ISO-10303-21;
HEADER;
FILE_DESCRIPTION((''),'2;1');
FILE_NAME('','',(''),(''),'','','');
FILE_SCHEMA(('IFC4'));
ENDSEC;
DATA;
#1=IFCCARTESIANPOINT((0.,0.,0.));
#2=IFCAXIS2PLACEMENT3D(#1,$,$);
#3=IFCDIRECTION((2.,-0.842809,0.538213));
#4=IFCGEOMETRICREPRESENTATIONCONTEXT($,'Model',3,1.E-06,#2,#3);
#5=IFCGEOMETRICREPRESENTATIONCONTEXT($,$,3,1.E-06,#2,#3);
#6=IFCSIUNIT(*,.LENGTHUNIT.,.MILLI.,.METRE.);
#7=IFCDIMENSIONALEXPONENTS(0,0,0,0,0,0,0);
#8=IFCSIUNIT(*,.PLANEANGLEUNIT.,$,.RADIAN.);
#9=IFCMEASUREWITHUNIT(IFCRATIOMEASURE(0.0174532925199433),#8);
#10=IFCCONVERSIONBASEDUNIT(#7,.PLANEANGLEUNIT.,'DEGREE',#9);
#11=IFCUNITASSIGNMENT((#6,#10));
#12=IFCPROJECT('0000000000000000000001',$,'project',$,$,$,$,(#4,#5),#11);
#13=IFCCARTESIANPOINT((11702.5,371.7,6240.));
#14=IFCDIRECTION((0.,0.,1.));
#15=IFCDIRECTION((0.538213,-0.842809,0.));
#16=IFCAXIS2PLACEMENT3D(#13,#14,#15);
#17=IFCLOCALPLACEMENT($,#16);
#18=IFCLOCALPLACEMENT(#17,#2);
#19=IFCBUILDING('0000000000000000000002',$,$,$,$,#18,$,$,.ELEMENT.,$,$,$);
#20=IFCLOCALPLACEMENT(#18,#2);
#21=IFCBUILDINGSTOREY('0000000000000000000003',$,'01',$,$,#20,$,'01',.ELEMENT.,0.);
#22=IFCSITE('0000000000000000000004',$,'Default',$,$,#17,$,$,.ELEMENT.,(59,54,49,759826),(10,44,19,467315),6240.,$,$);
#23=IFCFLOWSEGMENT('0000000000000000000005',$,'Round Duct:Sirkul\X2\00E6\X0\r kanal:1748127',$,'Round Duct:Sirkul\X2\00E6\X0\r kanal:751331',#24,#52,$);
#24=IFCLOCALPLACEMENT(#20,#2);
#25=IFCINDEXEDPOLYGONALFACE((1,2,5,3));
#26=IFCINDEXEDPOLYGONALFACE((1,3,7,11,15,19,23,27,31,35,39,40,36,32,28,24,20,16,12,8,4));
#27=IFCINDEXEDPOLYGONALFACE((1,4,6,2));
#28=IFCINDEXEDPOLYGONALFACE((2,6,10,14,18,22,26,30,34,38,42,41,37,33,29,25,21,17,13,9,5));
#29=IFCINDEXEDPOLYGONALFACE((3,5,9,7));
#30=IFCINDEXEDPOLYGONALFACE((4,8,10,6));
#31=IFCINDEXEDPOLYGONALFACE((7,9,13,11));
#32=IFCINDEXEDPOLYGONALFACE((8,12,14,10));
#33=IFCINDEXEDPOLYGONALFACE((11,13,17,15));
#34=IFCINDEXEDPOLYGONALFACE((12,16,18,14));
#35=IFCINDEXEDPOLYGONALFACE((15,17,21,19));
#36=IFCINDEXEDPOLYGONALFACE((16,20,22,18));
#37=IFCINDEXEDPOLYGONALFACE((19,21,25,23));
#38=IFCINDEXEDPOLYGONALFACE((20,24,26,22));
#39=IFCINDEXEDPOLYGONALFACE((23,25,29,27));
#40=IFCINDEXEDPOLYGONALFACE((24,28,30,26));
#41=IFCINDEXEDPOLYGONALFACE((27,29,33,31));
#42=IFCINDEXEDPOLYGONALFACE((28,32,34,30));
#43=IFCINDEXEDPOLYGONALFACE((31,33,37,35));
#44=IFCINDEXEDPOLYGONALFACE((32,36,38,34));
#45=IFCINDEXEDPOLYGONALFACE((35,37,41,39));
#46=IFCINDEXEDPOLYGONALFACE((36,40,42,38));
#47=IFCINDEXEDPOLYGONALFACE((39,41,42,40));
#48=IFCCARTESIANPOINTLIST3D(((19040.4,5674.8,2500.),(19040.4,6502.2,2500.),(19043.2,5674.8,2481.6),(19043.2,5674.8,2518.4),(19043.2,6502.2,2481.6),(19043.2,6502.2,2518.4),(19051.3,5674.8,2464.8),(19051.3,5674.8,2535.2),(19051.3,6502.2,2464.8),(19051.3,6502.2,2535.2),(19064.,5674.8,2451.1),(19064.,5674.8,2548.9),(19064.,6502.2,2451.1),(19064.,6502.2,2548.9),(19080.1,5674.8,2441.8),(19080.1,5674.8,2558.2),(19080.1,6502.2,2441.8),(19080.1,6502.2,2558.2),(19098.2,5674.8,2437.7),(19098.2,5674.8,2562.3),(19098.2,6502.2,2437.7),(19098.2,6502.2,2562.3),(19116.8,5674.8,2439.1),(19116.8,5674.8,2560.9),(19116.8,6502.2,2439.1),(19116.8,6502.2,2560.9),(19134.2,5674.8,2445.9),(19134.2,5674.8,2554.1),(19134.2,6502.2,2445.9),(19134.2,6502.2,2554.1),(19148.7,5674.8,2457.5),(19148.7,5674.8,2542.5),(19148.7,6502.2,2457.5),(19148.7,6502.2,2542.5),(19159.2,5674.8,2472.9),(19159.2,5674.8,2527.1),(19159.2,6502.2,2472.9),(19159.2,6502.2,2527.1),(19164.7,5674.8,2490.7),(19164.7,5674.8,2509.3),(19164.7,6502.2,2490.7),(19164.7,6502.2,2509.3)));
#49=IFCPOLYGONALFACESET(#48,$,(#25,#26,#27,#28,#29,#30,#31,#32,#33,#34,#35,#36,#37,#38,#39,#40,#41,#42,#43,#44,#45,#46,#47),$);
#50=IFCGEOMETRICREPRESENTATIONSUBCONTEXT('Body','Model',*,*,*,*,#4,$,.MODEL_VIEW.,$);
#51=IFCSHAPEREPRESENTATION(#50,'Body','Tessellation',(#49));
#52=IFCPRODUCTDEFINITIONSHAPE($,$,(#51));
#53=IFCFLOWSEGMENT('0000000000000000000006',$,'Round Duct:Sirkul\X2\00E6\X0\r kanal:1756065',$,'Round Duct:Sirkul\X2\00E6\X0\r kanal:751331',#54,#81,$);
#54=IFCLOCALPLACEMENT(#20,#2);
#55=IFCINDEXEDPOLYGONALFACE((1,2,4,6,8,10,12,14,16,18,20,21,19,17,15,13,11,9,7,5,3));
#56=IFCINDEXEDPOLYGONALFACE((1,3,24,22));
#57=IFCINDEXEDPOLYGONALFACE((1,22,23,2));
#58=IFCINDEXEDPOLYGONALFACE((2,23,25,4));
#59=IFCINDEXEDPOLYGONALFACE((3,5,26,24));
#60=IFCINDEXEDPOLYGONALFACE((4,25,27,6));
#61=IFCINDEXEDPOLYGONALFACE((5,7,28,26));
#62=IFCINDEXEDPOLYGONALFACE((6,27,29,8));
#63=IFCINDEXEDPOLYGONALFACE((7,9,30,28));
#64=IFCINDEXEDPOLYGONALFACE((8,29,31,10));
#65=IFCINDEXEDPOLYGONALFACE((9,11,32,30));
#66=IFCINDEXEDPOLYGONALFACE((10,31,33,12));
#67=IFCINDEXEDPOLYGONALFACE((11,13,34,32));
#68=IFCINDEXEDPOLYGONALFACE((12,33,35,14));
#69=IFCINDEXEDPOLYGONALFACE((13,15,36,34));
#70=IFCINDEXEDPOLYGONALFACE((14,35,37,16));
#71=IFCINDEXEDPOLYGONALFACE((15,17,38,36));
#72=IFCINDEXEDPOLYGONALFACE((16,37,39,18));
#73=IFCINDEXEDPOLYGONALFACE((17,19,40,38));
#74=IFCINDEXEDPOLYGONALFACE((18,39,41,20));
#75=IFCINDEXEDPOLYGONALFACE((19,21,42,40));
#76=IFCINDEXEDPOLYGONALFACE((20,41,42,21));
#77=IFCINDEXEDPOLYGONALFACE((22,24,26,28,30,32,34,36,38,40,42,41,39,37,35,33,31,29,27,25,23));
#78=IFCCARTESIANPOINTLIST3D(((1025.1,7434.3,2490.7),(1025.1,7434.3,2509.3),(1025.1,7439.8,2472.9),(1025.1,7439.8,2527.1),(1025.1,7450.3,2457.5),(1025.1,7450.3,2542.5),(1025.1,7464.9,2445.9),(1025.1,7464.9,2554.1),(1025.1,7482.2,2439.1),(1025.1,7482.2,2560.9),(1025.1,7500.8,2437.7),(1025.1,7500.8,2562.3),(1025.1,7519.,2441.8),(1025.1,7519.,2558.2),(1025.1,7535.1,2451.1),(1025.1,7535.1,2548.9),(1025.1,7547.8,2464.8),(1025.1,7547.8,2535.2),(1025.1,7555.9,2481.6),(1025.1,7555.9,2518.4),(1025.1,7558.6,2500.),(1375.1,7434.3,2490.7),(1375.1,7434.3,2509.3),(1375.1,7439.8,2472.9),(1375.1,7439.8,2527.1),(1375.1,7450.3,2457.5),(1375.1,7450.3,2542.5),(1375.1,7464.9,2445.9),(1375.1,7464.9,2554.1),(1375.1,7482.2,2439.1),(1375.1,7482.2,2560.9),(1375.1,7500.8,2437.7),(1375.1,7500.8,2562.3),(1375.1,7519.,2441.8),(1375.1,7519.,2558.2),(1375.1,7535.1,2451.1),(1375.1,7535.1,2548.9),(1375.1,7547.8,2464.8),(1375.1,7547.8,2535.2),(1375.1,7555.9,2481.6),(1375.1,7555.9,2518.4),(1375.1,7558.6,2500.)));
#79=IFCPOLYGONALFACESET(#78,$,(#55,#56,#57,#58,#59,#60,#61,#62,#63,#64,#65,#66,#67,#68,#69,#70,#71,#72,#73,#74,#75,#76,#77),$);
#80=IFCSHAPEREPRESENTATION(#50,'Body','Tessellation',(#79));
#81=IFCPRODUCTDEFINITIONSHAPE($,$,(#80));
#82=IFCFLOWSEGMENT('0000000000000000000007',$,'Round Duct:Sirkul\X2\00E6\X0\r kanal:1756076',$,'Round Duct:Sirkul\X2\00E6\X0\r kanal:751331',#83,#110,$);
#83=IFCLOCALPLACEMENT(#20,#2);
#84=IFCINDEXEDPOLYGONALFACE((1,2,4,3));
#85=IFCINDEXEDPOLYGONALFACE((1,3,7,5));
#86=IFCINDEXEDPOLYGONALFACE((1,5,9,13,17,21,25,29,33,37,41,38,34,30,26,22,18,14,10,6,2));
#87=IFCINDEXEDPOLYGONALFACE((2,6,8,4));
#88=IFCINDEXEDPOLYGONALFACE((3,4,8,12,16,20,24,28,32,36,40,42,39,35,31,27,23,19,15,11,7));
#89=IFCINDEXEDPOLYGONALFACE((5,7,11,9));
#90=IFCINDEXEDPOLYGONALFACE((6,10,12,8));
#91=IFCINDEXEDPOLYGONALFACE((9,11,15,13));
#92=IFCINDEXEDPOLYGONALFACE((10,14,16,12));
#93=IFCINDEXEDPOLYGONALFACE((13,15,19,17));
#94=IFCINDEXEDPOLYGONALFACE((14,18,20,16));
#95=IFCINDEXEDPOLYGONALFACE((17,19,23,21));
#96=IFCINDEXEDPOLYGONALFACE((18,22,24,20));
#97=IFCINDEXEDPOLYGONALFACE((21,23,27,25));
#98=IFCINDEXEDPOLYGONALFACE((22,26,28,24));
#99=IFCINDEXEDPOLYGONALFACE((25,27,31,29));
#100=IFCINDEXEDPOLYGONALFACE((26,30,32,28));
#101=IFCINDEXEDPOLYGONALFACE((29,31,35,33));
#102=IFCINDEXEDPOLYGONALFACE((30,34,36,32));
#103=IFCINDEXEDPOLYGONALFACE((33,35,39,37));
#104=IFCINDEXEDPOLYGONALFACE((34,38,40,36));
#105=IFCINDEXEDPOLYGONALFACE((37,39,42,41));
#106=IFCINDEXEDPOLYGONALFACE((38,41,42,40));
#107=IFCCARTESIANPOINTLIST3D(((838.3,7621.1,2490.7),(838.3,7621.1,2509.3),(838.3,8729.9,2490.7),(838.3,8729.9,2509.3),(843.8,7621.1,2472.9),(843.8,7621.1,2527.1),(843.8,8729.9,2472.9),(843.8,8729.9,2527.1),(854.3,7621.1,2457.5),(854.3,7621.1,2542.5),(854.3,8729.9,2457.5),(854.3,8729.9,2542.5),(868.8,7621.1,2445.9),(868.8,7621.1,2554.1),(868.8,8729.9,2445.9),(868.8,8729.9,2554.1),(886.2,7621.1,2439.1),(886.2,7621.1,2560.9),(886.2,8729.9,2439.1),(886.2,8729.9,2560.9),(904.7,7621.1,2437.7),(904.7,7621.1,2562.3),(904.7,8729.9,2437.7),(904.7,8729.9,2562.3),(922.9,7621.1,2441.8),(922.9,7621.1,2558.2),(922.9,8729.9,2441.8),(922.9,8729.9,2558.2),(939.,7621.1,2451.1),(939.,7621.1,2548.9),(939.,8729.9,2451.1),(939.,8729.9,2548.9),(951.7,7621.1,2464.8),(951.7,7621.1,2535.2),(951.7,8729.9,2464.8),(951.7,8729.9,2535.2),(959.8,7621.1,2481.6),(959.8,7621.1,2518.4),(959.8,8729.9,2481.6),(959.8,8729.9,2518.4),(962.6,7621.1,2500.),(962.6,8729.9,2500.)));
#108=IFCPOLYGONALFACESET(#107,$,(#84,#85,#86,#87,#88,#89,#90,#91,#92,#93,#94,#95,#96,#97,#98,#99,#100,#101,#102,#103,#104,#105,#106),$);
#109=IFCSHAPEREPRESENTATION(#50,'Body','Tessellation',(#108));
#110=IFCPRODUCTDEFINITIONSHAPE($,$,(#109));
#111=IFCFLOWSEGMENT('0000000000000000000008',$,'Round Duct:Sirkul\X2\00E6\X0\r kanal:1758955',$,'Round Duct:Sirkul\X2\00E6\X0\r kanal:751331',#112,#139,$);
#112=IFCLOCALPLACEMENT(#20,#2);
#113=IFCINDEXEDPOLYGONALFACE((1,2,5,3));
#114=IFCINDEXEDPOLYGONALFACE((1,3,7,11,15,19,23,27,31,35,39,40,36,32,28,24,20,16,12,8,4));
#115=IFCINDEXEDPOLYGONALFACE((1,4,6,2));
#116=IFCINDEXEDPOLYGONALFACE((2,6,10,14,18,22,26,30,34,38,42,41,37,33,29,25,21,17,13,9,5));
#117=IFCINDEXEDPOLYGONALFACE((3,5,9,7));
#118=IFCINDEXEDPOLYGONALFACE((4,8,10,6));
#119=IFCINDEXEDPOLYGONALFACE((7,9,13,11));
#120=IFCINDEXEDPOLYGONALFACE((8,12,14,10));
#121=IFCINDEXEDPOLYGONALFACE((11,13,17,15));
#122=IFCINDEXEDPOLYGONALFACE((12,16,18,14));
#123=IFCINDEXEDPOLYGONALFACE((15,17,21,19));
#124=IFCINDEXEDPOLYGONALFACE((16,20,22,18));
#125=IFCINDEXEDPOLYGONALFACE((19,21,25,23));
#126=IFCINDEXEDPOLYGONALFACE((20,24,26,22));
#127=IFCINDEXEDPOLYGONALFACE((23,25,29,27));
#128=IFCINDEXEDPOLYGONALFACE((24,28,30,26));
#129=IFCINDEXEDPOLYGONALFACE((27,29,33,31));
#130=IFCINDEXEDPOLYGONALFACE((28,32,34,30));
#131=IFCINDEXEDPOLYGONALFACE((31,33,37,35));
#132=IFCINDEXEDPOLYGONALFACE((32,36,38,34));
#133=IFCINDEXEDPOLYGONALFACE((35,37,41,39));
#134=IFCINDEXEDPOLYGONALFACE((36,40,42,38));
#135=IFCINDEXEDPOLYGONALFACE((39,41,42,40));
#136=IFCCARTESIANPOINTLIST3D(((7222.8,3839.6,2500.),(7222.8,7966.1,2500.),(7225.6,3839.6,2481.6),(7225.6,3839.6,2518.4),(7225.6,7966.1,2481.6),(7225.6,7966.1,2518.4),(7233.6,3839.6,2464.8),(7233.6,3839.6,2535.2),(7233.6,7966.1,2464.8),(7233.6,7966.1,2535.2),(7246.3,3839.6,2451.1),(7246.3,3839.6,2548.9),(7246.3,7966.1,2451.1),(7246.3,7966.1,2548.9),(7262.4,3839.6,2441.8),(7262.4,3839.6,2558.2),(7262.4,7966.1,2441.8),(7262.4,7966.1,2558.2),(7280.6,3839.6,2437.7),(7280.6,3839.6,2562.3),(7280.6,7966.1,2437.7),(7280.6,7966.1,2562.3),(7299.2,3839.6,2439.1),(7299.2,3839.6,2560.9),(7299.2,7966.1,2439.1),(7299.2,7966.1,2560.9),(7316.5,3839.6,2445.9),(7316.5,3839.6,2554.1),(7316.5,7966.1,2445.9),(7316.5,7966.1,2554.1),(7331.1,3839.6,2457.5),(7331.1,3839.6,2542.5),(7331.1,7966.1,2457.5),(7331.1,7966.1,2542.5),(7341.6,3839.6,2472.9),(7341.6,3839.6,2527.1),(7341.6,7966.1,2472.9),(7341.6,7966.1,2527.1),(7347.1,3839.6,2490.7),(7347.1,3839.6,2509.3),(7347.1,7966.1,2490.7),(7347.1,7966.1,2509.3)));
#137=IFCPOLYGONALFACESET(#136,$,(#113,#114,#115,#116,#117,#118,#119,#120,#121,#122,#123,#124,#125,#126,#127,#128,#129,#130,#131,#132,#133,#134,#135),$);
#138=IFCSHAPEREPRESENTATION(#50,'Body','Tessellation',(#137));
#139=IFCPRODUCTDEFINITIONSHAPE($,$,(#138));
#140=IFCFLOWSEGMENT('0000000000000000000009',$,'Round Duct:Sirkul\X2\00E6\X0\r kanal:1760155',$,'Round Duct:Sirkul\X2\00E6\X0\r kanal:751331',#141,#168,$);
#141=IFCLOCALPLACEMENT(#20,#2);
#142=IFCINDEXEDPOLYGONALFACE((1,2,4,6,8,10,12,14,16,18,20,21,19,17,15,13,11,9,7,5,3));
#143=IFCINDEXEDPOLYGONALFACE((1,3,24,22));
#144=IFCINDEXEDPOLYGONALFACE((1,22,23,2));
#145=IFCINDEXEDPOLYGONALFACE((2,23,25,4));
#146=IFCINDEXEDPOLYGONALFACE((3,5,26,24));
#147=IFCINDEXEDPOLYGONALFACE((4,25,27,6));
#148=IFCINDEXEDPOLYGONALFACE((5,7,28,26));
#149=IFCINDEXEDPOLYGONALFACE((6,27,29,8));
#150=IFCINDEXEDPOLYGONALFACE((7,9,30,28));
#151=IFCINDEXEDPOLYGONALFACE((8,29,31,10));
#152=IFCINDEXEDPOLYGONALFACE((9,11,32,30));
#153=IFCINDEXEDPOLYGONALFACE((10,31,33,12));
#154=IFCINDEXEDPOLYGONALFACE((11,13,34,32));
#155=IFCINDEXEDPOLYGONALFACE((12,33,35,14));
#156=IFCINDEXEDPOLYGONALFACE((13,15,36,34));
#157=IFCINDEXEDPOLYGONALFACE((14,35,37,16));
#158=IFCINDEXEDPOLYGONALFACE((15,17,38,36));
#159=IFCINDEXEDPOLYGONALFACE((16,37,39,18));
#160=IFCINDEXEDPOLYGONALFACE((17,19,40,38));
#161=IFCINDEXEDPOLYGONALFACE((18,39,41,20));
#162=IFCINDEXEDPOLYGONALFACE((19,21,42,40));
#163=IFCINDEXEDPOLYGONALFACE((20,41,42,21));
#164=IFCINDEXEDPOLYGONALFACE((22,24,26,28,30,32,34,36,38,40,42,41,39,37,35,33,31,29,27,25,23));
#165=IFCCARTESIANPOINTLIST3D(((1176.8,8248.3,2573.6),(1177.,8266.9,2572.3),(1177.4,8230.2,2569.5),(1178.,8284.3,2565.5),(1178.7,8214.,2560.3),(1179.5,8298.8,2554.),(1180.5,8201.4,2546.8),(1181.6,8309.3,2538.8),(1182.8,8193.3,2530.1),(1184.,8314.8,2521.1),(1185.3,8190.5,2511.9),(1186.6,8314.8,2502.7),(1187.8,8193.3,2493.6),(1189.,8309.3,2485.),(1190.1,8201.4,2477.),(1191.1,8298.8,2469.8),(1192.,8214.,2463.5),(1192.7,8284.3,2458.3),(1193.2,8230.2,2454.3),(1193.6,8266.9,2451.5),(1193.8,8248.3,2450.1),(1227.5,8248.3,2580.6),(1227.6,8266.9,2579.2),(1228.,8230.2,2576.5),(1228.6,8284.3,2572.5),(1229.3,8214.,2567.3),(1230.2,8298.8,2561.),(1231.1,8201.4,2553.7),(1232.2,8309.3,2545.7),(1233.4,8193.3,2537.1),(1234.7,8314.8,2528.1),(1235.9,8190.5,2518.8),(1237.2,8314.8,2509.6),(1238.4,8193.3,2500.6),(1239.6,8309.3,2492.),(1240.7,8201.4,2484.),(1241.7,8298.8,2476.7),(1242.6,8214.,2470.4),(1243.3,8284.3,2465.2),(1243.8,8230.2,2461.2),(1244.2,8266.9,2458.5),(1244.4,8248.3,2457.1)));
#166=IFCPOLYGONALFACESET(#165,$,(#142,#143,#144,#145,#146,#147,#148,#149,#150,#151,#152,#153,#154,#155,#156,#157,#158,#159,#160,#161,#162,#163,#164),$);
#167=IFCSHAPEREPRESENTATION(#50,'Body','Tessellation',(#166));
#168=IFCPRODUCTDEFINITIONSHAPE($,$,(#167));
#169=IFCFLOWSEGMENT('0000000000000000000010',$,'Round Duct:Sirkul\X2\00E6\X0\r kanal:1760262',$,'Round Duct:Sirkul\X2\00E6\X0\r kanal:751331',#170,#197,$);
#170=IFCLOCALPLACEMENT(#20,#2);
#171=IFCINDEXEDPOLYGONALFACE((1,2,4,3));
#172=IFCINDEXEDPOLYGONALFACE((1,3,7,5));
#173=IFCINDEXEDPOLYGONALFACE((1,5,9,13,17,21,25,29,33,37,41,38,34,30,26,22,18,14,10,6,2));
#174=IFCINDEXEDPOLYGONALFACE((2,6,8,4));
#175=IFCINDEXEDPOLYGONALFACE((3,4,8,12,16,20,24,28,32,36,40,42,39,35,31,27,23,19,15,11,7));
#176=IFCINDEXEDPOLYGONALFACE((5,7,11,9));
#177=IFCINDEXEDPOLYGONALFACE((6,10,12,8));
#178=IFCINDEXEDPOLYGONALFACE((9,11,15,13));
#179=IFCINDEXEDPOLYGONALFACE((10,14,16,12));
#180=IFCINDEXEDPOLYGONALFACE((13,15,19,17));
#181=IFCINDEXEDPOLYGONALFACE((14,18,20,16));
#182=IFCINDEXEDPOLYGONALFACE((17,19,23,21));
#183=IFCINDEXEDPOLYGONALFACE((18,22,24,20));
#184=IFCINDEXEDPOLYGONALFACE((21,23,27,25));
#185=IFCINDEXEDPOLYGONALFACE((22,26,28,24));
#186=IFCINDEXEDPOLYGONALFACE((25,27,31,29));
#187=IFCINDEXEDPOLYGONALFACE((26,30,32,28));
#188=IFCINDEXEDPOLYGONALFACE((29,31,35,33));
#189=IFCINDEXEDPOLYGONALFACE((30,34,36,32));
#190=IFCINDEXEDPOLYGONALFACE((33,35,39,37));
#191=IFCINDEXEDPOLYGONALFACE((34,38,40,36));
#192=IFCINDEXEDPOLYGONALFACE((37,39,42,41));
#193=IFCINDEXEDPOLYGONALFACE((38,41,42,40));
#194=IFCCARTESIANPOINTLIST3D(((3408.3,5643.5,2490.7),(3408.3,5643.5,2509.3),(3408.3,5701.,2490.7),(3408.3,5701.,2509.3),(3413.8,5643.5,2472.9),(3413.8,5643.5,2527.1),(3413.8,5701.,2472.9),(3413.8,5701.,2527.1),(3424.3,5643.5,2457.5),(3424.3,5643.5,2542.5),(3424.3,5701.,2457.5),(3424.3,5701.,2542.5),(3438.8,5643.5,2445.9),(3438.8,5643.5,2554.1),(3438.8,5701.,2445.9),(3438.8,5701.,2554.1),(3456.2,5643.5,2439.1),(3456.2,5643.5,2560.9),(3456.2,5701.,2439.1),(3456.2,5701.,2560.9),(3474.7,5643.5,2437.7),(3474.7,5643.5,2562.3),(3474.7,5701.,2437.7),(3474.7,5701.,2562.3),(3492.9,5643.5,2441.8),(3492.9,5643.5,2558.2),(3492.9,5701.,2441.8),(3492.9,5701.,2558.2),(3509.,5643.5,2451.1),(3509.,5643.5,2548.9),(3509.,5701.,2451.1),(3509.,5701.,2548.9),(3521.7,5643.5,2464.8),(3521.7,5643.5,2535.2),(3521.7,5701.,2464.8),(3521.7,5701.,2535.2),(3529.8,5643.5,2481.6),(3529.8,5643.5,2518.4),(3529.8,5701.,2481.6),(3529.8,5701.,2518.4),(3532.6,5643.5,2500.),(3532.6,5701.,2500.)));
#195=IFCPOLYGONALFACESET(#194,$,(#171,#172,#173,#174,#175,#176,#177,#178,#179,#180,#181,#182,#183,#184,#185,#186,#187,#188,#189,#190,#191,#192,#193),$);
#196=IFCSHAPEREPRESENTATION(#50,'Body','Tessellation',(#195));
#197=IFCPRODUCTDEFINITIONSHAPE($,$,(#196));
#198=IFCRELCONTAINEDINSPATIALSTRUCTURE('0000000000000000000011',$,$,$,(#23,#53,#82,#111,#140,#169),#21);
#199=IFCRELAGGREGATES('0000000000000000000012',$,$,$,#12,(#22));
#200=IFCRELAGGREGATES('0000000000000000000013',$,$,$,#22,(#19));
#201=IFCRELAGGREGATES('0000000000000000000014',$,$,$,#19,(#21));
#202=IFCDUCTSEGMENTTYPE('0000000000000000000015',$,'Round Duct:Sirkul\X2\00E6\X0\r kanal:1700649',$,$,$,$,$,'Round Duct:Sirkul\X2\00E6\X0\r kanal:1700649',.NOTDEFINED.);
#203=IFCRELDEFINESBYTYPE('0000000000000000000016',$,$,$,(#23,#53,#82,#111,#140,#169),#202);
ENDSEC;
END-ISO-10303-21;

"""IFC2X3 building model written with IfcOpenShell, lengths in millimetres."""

from ifc_helpers import new_model, entity, si_unit, converted_unit, direction, frame, frame_2d, origin, place, context, subcontext, project, spatial, circle, extrude, type_object, element, save


model = new_model("IFC2X3")

# Units and contexts
model_context = context("Model", 3, precision=1e-06, world=origin(), true_north=direction((2.0, -0.842809, 0.538213)))
context_of_model = context(None, 3, precision=1e-06, world=origin(), true_north=direction((2.0, -0.842809, 0.538213)))
body_context = subcontext(model_context, "Body", "Model", "MODEL_VIEW")
ifc_project = project(units=[si_unit("LENGTHUNIT", "METRE", prefix="MILLI"), converted_unit("PLANEANGLEUNIT", "DEGREE", entity("IfcRatioMeasure", 0.0174532925199433), si_unit("PLANEANGLEUNIT", "RADIAN"), dimensions=[0, 0, 0, 0, 0, 0, 0])], contexts=[model_context, context_of_model])

# Site, building, storey
site_placement = place(None, frame((11702.5, 371.7, 6240.0), z_axis=(0.0, 0.0, 1.0), x_axis=(0.538213, -0.842809, 0.0)))
site = spatial("IfcSite", under=ifc_project, at=site_placement, Name="Default", CompositionType="ELEMENT", RefLatitude=(59, 54, 49, 759826), RefLongitude=(10, 44, 19, 467315), RefElevation=6240.0)
building_placement = place(site_placement, origin())
building = spatial("IfcBuilding", under=site, at=building_placement, CompositionType="ELEMENT")
storey_placement = place(building_placement, origin())
storey = spatial("IfcBuildingStorey", under=building, at=storey_placement, Name="01", LongName="01", CompositionType="ELEMENT", Elevation=0.0)

# Flow segments
duct_segment_type_1 = type_object("IfcDuctSegmentType", Name="Round Duct:Sirkulær kanal:1700649", ElementType="Round Duct:Sirkulær kanal:1700649", PredefinedType="NOTDEFINED")
flow_segment_1_placement = place(storey_placement, origin())
element("IfcFlowSegment", 1, at=flow_segment_1_placement, inside=storey, type_object=duct_segment_type_1, Name="Round Duct:Sirkulær kanal:1748127", ObjectType="Round Duct:Sirkulær kanal:751331", context=body_context, shape_type="SweptSolid", body=[
    extrude(circle(Radius=62.5, at=frame_2d((0.0, 0.0), x_axis=(1.0, 0.0))), frame((19102.9, 5674.8, 2500.0), z_axis=(0.0, 1.0, 0.0), x_axis=(-1.0, 0.0, 0.0)), (0.0, 0.0, 1.0), 827.5),
])
flow_segment_2_placement = place(storey_placement, origin())
element("IfcFlowSegment", 2, at=flow_segment_2_placement, inside=storey, type_object=duct_segment_type_1, Name="Round Duct:Sirkulær kanal:1756065", ObjectType="Round Duct:Sirkulær kanal:751331", context=body_context, shape_type="SweptSolid", body=[
    extrude(circle(Radius=62.5, at=frame_2d((0.0, 0.0), x_axis=(1.0, 0.0))), frame((1025.1, 7496.1, 2500.0), z_axis=(1.0, 0.0, 0.0), x_axis=(0.0, 1.0, 0.0)), (0.0, 0.0, 1.0), 350.0),
])
flow_segment_3_placement = place(storey_placement, origin())
element("IfcFlowSegment", 3, at=flow_segment_3_placement, inside=storey, type_object=duct_segment_type_1, Name="Round Duct:Sirkulær kanal:1756076", ObjectType="Round Duct:Sirkulær kanal:751331", context=body_context, shape_type="SweptSolid", body=[
    extrude(circle(Radius=62.5, at=frame_2d((0.0, 0.0), x_axis=(1.0, 0.0))), frame((900.1, 7621.1, 2500.0), z_axis=(0.0, 1.0, 0.0), x_axis=(1.0, 0.0, 0.0)), (0.0, 0.0, 1.0), 1108.8),
])
flow_segment_4_placement = place(storey_placement, origin())
element("IfcFlowSegment", 4, at=flow_segment_4_placement, inside=storey, type_object=duct_segment_type_1, Name="Round Duct:Sirkulær kanal:1758955", ObjectType="Round Duct:Sirkulær kanal:751331", context=body_context, shape_type="SweptSolid", body=[
    extrude(circle(Radius=62.5, at=frame_2d((0.0, 0.0), x_axis=(1.0, 0.0))), frame((7285.3, 3839.6, 2500.0), z_axis=(0.0, 1.0, 0.0), x_axis=(-1.0, 0.0, 0.0)), (0.0, 0.0, 1.0), 4126.5),
])
flow_segment_5_placement = place(storey_placement, origin())
element("IfcFlowSegment", 5, at=flow_segment_5_placement, inside=storey, type_object=duct_segment_type_1, Name="Round Duct:Sirkulær kanal:1760155", ObjectType="Round Duct:Sirkulær kanal:751331", context=body_context, shape_type="SweptSolid", body=[
    extrude(circle(Radius=62.5, at=frame_2d((0.0, 0.0), x_axis=(1.0, 0.0))), frame((1185.3, 8253.0, 2511.9), z_axis=(0.990717, 0.0, 0.135938), x_axis=(0.0, -1.0, 0.0)), (0.0, 0.0, 1.0), 51.1),
])
flow_segment_6_placement = place(storey_placement, origin())
element("IfcFlowSegment", 6, at=flow_segment_6_placement, inside=storey, type_object=duct_segment_type_1, Name="Round Duct:Sirkulær kanal:1760262", ObjectType="Round Duct:Sirkulær kanal:751331", context=body_context, shape_type="SweptSolid", body=[
    extrude(circle(Radius=62.5, at=frame_2d((0.0, 0.0), x_axis=(1.0, 0.0))), frame((3470.1, 5643.5, 2500.0), z_axis=(0.0, 1.0, 0.0), x_axis=(1.0, 0.0, 0.0)), (0.0, 0.0, 1.0), 57.5),
])

save(model, "model.ifc")
